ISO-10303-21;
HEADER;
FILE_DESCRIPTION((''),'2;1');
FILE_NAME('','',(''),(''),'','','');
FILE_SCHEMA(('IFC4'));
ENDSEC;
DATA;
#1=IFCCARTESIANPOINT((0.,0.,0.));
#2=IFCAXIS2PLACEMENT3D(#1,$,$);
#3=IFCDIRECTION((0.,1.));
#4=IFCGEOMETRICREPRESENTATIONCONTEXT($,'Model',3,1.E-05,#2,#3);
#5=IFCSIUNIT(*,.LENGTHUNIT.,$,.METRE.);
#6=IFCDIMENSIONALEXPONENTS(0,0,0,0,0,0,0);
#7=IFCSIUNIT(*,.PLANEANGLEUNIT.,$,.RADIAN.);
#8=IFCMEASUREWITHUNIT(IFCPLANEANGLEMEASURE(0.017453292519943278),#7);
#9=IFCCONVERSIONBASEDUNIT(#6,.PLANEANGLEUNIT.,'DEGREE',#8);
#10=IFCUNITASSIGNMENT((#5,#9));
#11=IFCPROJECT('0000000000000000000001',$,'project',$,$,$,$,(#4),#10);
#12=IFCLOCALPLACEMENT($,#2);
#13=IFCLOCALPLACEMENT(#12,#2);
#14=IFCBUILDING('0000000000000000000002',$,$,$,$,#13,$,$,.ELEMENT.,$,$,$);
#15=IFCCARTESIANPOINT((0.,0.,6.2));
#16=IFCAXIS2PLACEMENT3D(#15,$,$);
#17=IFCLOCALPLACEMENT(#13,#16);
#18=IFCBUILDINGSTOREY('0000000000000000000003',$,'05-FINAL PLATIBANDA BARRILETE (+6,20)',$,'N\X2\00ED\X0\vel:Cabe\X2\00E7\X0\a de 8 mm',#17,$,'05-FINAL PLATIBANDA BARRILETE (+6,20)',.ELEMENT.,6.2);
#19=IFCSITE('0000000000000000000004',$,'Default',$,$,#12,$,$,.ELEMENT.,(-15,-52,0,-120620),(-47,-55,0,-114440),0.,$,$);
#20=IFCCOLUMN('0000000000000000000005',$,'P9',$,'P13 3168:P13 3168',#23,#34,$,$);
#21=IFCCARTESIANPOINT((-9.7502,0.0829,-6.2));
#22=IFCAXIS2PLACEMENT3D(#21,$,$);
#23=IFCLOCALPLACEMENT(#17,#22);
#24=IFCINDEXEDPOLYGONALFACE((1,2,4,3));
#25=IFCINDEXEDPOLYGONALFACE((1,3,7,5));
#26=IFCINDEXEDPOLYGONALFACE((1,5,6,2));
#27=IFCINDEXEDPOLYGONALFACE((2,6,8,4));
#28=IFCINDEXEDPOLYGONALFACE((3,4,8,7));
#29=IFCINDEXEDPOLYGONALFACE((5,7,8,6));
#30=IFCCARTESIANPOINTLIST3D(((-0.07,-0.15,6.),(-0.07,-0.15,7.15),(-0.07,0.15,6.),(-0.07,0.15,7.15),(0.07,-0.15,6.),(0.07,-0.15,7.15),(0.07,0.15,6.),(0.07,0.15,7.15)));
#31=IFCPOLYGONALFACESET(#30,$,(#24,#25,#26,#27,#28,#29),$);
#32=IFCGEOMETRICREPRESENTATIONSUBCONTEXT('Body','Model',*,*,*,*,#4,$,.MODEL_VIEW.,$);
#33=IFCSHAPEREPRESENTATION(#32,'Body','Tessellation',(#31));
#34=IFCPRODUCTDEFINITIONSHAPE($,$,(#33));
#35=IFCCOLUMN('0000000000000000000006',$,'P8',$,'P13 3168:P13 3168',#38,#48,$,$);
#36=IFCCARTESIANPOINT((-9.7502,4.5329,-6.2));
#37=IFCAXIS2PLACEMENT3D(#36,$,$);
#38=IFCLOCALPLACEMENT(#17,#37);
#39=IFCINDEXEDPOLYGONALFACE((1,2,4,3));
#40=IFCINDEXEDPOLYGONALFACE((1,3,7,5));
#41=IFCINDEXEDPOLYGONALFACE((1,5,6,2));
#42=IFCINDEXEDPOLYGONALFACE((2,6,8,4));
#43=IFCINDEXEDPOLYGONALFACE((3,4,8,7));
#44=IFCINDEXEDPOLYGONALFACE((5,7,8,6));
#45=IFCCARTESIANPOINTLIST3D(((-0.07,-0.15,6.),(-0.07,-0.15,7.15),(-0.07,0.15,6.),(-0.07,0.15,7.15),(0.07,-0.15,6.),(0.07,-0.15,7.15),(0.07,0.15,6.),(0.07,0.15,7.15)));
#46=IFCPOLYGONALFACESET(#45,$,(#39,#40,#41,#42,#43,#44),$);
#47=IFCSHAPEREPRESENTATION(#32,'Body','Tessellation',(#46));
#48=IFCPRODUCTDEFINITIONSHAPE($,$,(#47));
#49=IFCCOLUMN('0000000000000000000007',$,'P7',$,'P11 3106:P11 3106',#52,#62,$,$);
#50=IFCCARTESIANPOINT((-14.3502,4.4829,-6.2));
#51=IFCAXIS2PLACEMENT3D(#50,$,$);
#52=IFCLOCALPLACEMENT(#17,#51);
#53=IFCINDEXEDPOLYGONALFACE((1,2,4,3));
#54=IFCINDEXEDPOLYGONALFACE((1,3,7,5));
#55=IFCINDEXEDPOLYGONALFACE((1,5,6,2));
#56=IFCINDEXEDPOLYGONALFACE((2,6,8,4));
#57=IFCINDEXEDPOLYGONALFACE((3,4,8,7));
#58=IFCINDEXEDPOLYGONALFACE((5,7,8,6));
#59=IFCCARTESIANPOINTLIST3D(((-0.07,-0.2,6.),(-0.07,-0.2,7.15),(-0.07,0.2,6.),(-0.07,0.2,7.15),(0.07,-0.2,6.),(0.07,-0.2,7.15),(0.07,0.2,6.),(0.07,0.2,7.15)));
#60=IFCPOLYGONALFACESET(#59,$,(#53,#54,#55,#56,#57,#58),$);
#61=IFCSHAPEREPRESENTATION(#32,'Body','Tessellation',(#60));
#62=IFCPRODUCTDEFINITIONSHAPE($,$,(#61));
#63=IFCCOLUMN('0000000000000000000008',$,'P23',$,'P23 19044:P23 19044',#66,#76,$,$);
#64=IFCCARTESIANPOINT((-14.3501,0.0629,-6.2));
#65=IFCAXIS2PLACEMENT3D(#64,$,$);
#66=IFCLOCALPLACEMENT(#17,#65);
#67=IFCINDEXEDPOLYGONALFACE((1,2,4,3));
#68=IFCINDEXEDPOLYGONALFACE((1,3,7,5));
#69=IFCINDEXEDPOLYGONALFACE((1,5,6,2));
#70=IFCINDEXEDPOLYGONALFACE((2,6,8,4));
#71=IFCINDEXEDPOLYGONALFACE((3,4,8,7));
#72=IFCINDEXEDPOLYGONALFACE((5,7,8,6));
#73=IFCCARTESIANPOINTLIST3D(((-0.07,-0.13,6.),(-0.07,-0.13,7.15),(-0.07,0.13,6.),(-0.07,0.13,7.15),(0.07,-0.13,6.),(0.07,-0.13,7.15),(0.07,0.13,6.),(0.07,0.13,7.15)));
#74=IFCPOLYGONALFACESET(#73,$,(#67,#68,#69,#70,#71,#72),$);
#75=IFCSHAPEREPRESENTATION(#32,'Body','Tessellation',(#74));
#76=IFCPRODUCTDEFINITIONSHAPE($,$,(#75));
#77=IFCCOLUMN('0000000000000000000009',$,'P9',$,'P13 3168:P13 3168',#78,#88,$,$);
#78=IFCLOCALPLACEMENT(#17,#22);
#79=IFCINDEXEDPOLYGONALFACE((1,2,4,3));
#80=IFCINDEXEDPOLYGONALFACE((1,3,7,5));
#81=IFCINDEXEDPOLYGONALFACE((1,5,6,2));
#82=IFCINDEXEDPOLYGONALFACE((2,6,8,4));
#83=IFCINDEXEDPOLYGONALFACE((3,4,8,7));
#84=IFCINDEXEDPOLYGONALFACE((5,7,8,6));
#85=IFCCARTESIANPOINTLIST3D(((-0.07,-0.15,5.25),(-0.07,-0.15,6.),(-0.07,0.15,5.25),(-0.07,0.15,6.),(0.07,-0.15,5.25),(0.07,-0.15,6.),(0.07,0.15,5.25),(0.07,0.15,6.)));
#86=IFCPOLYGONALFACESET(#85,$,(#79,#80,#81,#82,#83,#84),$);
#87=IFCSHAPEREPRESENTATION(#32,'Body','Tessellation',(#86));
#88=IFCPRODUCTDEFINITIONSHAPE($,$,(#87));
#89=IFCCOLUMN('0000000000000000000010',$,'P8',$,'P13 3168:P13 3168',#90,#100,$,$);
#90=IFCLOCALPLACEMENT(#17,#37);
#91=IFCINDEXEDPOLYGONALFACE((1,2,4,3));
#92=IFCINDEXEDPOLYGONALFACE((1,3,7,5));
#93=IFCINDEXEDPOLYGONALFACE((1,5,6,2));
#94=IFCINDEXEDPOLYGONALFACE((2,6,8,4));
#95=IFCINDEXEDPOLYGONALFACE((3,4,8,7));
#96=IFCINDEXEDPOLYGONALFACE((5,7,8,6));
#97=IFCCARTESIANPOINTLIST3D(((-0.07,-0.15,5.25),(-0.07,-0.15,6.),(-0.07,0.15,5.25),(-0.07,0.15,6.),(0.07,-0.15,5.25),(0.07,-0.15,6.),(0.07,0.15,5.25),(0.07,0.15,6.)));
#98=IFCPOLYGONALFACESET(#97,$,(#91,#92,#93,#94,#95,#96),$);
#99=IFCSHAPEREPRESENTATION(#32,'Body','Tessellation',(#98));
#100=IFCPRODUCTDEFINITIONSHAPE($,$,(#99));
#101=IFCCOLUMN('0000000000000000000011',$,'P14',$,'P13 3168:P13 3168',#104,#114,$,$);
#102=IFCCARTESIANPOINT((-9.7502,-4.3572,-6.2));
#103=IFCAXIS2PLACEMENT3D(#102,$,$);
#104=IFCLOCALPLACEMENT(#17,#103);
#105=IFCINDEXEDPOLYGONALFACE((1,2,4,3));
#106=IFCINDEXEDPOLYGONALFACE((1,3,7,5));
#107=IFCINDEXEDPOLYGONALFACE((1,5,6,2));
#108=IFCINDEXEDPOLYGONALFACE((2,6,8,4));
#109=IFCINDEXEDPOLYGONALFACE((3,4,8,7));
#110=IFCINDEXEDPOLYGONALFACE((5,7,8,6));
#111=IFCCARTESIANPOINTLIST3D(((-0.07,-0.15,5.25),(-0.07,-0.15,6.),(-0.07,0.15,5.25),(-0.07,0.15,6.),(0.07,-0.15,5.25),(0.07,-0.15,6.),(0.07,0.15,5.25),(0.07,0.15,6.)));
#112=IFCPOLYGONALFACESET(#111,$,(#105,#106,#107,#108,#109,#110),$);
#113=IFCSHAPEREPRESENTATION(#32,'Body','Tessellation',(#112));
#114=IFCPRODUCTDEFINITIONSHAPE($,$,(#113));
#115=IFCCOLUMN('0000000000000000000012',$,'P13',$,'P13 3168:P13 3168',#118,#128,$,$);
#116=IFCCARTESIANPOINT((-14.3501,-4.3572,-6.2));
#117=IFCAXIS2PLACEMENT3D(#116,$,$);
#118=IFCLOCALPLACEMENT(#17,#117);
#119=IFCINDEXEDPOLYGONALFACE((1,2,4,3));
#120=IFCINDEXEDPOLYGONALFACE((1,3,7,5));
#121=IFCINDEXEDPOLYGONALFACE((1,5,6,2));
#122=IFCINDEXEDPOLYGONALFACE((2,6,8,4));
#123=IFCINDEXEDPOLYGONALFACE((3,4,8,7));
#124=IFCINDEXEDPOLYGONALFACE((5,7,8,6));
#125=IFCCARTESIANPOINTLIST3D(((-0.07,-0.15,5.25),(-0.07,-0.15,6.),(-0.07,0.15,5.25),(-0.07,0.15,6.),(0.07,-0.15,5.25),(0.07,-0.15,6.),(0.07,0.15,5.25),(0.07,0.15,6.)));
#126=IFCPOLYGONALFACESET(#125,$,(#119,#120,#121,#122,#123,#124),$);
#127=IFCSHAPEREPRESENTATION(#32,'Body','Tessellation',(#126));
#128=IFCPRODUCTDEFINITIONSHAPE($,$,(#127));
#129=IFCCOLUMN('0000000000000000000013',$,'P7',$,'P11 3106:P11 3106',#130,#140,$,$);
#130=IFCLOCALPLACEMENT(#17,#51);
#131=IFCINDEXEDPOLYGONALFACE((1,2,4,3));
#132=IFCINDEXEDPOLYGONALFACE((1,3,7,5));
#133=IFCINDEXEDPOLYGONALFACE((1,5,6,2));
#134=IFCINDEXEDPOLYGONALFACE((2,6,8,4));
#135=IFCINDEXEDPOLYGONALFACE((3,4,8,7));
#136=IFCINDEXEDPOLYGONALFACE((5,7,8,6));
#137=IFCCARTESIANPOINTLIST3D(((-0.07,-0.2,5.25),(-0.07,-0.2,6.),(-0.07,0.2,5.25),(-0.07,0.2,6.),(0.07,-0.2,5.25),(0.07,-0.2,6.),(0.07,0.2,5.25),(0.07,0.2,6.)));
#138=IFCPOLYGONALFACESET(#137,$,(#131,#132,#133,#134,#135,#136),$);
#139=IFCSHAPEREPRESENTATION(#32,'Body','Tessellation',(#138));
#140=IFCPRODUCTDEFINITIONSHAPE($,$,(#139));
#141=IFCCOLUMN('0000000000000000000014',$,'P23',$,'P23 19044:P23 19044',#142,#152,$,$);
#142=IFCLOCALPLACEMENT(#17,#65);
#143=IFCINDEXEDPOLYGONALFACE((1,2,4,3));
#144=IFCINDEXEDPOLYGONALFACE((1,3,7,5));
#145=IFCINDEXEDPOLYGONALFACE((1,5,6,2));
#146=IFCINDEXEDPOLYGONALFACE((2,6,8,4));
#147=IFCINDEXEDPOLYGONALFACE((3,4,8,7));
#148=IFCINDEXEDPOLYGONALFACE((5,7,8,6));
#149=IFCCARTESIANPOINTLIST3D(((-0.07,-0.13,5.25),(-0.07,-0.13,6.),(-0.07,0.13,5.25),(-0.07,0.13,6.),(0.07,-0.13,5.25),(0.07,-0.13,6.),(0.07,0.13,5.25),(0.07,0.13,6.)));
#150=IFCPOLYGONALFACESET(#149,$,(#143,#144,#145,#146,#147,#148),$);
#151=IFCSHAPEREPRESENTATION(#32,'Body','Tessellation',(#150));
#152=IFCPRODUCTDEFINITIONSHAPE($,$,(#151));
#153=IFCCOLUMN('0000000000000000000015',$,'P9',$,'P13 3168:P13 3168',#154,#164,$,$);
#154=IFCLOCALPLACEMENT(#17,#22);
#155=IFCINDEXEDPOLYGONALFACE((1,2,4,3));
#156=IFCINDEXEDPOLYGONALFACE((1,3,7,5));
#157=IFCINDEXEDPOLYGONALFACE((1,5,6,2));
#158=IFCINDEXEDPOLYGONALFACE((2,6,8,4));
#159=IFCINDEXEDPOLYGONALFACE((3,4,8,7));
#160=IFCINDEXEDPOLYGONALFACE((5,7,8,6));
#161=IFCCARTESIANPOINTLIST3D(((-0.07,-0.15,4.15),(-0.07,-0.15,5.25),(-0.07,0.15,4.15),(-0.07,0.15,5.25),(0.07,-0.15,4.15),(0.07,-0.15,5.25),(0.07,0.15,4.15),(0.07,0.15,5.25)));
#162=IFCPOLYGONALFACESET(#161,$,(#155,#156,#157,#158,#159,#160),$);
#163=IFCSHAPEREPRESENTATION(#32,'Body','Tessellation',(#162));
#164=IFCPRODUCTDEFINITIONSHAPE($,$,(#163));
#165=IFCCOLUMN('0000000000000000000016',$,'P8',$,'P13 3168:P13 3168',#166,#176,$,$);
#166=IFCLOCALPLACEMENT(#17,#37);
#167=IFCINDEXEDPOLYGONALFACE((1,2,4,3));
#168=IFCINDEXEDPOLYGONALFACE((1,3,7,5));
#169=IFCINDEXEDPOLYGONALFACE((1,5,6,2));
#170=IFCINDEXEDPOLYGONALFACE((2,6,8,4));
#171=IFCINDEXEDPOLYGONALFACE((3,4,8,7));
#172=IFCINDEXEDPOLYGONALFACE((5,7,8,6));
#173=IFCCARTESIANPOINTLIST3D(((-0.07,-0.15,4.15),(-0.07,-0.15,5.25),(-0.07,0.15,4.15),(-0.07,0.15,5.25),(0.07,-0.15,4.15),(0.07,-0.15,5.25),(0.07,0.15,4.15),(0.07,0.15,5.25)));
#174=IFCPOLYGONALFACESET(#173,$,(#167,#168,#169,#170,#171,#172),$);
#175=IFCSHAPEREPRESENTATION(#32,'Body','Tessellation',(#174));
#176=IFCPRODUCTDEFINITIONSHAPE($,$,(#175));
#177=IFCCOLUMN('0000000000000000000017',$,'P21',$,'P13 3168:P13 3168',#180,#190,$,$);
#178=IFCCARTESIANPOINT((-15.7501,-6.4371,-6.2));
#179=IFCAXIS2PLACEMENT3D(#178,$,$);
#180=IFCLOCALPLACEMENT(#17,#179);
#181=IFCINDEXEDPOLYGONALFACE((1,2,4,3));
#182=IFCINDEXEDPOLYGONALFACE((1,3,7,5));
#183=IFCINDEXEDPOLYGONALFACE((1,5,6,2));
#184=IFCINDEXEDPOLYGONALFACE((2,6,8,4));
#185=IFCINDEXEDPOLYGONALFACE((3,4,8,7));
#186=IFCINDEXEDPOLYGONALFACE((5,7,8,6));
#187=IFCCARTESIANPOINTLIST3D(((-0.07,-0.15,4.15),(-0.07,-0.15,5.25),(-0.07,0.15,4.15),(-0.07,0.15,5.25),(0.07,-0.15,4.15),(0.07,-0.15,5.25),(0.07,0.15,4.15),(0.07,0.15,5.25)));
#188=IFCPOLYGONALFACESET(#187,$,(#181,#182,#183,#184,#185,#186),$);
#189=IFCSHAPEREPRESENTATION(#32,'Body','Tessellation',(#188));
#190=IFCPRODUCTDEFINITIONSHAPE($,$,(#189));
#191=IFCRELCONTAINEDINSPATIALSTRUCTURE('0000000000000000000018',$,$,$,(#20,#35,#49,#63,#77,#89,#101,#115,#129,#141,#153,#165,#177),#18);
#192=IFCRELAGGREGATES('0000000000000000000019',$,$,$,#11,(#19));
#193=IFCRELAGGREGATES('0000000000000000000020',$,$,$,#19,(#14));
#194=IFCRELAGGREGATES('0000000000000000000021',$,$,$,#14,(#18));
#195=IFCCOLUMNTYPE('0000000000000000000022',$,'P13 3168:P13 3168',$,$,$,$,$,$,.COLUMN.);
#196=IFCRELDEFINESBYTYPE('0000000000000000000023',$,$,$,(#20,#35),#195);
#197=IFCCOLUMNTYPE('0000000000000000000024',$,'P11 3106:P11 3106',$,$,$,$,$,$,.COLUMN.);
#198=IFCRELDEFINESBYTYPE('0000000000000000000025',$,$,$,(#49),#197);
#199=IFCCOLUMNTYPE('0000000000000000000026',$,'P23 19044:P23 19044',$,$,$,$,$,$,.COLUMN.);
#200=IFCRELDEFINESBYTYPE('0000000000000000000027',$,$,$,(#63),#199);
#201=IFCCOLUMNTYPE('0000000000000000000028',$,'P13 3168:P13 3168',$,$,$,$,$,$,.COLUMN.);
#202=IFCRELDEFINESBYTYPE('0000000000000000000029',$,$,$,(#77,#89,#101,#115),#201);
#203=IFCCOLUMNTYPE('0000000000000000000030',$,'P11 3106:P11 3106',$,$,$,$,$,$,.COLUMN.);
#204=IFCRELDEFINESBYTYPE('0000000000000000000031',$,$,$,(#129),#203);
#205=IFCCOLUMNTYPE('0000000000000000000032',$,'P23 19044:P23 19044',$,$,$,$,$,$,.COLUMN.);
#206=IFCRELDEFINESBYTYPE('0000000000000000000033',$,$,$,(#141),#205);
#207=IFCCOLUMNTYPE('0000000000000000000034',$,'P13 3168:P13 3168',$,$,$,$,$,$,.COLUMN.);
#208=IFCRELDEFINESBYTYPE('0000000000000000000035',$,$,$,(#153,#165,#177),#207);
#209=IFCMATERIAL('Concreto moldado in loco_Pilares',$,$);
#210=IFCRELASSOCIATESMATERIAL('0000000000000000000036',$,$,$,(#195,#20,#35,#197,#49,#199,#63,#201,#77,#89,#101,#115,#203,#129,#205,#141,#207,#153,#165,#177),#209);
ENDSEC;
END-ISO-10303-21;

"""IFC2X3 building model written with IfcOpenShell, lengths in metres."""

from ifc_helpers import new_model, entity, si_unit, converted_unit, direction, frame, origin, origin_2d_with_axis, place, context, subcontext, project, spatial, rectangle, extrude, source, transform, mapped, material, type_object, type_shapes, element, save


model = new_model("IFC2X3")

# Units and contexts
model_context = context("Model", 3, precision=1e-05, world=origin(), true_north=direction((0.0, 1.0)))
body_context = subcontext(model_context, "Body", "Model", "MODEL_VIEW")
ifc_project = project(units=[si_unit("LENGTHUNIT", "METRE"), converted_unit("PLANEANGLEUNIT", "DEGREE", entity("IfcPlaneAngleMeasure", 0.017453292519943278), si_unit("PLANEANGLEUNIT", "RADIAN"), dimensions=[0, 0, 0, 0, 0, 0, 0])], contexts=[model_context])

# Site, building, storey
site_placement = place(None, origin())
site = spatial("IfcSite", under=ifc_project, at=site_placement, Name="Default", CompositionType="ELEMENT", RefLatitude=(-15, -52, 0, -120620), RefLongitude=(-47, -55, 0, -114440), RefElevation=0.0)
building_placement = place(site_placement, origin())
building = spatial("IfcBuilding", under=site, at=building_placement, CompositionType="ELEMENT")
storey_placement = place(building_placement, frame((0.0, 0.0, 6.2)))
storey = spatial("IfcBuildingStorey", under=building, at=storey_placement, Name="05-FINAL PLATIBANDA BARRILETE (+6,20)", ObjectType="Nível:Cabeça de 8 mm", LongName="05-FINAL PLATIBANDA BARRILETE (+6,20)", CompositionType="ELEMENT", Elevation=6.2)

# Columns
ifc_material_1 = material(Name="Concreto moldado in loco_Pilares")
column_type_1 = type_object("IfcColumnType", Name="P13 3168:P13 3168", PredefinedType="COLUMN", material=ifc_material_1)
shared_shape_1 = source(origin(), body_context, "Body", "SweptSolid", [
    extrude(rectangle(XDim=0.3, YDim=0.14, at=origin_2d_with_axis()), frame((0.0, 0.0, 6.0), z_axis=(0.0, 0.0, 1.0), x_axis=(0.0, -1.0, 0.0)), (0.0, 0.0, 1.0), 1.15),
])
type_shapes(column_type_1, [shared_shape_1])
for number, where, name in (
    (1, (-9.7502, 0.0829, -6.2), "P9"),
    (2, (-9.7502, 4.5329, -6.2), "P8"),
):
    element("IfcColumn", number, at=place(storey_placement, frame(where)), inside=storey, type_object=column_type_1, material=ifc_material_1, Name=name, ObjectType="P13 3168:P13 3168", context=body_context, shape_type="MappedRepresentation", body=[
        mapped(shared_shape_1, transform((0.0, 0.0, 0.0), scale=1.0)),
    ])
column_type_2 = type_object("IfcColumnType", Name="P11 3106:P11 3106", PredefinedType="COLUMN", material=ifc_material_1)
shared_shape_2 = source(origin(), body_context, "Body", "SweptSolid", [
    extrude(rectangle(XDim=0.4, YDim=0.14, at=origin_2d_with_axis()), frame((0.0, 0.0, 6.0), z_axis=(0.0, 0.0, 1.0), x_axis=(0.0, -1.0, 0.0)), (0.0, 0.0, 1.0), 1.15),
])
type_shapes(column_type_2, [shared_shape_2])
column_1_placement = place(storey_placement, frame((-14.3502, 4.4829, -6.2)))
element("IfcColumn", 3, at=column_1_placement, inside=storey, type_object=column_type_2, material=ifc_material_1, Name="P7", ObjectType="P11 3106:P11 3106", context=body_context, shape_type="MappedRepresentation", body=[
    mapped(shared_shape_2, transform((0.0, 0.0, 0.0), scale=1.0)),
])
column_type_3 = type_object("IfcColumnType", Name="P23 19044:P23 19044", PredefinedType="COLUMN", material=ifc_material_1)
shared_shape_3 = source(origin(), body_context, "Body", "SweptSolid", [
    extrude(rectangle(XDim=0.26, YDim=0.14, at=origin_2d_with_axis()), frame((0.0, 0.0, 6.0), z_axis=(0.0, 0.0, 1.0), x_axis=(0.0, -1.0, 0.0)), (0.0, 0.0, 1.0), 1.15),
])
type_shapes(column_type_3, [shared_shape_3])
column_2_placement = place(storey_placement, frame((-14.3501, 0.0629, -6.2)))
element("IfcColumn", 4, at=column_2_placement, inside=storey, type_object=column_type_3, material=ifc_material_1, Name="P23", ObjectType="P23 19044:P23 19044", context=body_context, shape_type="MappedRepresentation", body=[
    mapped(shared_shape_3, transform((0.0, 0.0, 0.0), scale=1.0)),
])
column_type_4 = type_object("IfcColumnType", Name="P13 3168:P13 3168", PredefinedType="COLUMN", material=ifc_material_1)
shared_shape_4 = source(origin(), body_context, "Body", "SweptSolid", [
    extrude(rectangle(XDim=0.3, YDim=0.14, at=origin_2d_with_axis()), frame((0.0, 0.0, 5.25), z_axis=(0.0, 0.0, 1.0), x_axis=(0.0, -1.0, 0.0)), (0.0, 0.0, 1.0), 0.75),
])
type_shapes(column_type_4, [shared_shape_4])
for number, where, name in (
    (5, (-9.7502, 0.0829, -6.2), "P9"),
    (6, (-9.7502, 4.5329, -6.2), "P8"),
    (7, (-9.7502, -4.3572, -6.2), "P14"),
    (8, (-14.3501, -4.3572, -6.2), "P13"),
):
    element("IfcColumn", number, at=place(storey_placement, frame(where)), inside=storey, type_object=column_type_4, material=ifc_material_1, Name=name, ObjectType="P13 3168:P13 3168", context=body_context, shape_type="MappedRepresentation", body=[
        mapped(shared_shape_4, transform((0.0, 0.0, 0.0), scale=1.0)),
    ])
column_type_5 = type_object("IfcColumnType", Name="P11 3106:P11 3106", PredefinedType="COLUMN", material=ifc_material_1)
shared_shape_5 = source(origin(), body_context, "Body", "SweptSolid", [
    extrude(rectangle(XDim=0.4, YDim=0.14, at=origin_2d_with_axis()), frame((0.0, 0.0, 5.25), z_axis=(0.0, 0.0, 1.0), x_axis=(0.0, -1.0, 0.0)), (0.0, 0.0, 1.0), 0.75),
])
type_shapes(column_type_5, [shared_shape_5])
column_3_placement = place(storey_placement, frame((-14.3502, 4.4829, -6.2)))
element("IfcColumn", 9, at=column_3_placement, inside=storey, type_object=column_type_5, material=ifc_material_1, Name="P7", ObjectType="P11 3106:P11 3106", context=body_context, shape_type="MappedRepresentation", body=[
    mapped(shared_shape_5, transform((0.0, 0.0, 0.0), scale=1.0)),
])
column_type_6 = type_object("IfcColumnType", Name="P23 19044:P23 19044", PredefinedType="COLUMN", material=ifc_material_1)
shared_shape_6 = source(origin(), body_context, "Body", "SweptSolid", [
    extrude(rectangle(XDim=0.26, YDim=0.14, at=origin_2d_with_axis()), frame((0.0, 0.0, 5.25), z_axis=(0.0, 0.0, 1.0), x_axis=(0.0, -1.0, 0.0)), (0.0, 0.0, 1.0), 0.75),
])
type_shapes(column_type_6, [shared_shape_6])
column_4_placement = place(storey_placement, frame((-14.3501, 0.0629, -6.2)))
element("IfcColumn", 10, at=column_4_placement, inside=storey, type_object=column_type_6, material=ifc_material_1, Name="P23", ObjectType="P23 19044:P23 19044", context=body_context, shape_type="MappedRepresentation", body=[
    mapped(shared_shape_6, transform((0.0, 0.0, 0.0), scale=1.0)),
])
column_type_7 = type_object("IfcColumnType", Name="P13 3168:P13 3168", PredefinedType="COLUMN", material=ifc_material_1)
shared_shape_7 = source(origin(), body_context, "Body", "SweptSolid", [
    extrude(rectangle(XDim=0.3, YDim=0.14, at=origin_2d_with_axis()), frame((0.0, 0.0, 4.15), z_axis=(0.0, 0.0, 1.0), x_axis=(0.0, -1.0, 0.0)), (0.0, 0.0, 1.0), 1.1),
])
type_shapes(column_type_7, [shared_shape_7])
for number, where, name in (
    (11, (-9.7502, 0.0829, -6.2), "P9"),
    (12, (-9.7502, 4.5329, -6.2), "P8"),
    (13, (-15.7501, -6.4371, -6.2), "P21"),
):
    element("IfcColumn", number, at=place(storey_placement, frame(where)), inside=storey, type_object=column_type_7, material=ifc_material_1, Name=name, ObjectType="P13 3168:P13 3168", context=body_context, shape_type="MappedRepresentation", body=[
        mapped(shared_shape_7, transform((0.0, 0.0, 0.0), scale=1.0)),
    ])

save(model, "model.ifc")
